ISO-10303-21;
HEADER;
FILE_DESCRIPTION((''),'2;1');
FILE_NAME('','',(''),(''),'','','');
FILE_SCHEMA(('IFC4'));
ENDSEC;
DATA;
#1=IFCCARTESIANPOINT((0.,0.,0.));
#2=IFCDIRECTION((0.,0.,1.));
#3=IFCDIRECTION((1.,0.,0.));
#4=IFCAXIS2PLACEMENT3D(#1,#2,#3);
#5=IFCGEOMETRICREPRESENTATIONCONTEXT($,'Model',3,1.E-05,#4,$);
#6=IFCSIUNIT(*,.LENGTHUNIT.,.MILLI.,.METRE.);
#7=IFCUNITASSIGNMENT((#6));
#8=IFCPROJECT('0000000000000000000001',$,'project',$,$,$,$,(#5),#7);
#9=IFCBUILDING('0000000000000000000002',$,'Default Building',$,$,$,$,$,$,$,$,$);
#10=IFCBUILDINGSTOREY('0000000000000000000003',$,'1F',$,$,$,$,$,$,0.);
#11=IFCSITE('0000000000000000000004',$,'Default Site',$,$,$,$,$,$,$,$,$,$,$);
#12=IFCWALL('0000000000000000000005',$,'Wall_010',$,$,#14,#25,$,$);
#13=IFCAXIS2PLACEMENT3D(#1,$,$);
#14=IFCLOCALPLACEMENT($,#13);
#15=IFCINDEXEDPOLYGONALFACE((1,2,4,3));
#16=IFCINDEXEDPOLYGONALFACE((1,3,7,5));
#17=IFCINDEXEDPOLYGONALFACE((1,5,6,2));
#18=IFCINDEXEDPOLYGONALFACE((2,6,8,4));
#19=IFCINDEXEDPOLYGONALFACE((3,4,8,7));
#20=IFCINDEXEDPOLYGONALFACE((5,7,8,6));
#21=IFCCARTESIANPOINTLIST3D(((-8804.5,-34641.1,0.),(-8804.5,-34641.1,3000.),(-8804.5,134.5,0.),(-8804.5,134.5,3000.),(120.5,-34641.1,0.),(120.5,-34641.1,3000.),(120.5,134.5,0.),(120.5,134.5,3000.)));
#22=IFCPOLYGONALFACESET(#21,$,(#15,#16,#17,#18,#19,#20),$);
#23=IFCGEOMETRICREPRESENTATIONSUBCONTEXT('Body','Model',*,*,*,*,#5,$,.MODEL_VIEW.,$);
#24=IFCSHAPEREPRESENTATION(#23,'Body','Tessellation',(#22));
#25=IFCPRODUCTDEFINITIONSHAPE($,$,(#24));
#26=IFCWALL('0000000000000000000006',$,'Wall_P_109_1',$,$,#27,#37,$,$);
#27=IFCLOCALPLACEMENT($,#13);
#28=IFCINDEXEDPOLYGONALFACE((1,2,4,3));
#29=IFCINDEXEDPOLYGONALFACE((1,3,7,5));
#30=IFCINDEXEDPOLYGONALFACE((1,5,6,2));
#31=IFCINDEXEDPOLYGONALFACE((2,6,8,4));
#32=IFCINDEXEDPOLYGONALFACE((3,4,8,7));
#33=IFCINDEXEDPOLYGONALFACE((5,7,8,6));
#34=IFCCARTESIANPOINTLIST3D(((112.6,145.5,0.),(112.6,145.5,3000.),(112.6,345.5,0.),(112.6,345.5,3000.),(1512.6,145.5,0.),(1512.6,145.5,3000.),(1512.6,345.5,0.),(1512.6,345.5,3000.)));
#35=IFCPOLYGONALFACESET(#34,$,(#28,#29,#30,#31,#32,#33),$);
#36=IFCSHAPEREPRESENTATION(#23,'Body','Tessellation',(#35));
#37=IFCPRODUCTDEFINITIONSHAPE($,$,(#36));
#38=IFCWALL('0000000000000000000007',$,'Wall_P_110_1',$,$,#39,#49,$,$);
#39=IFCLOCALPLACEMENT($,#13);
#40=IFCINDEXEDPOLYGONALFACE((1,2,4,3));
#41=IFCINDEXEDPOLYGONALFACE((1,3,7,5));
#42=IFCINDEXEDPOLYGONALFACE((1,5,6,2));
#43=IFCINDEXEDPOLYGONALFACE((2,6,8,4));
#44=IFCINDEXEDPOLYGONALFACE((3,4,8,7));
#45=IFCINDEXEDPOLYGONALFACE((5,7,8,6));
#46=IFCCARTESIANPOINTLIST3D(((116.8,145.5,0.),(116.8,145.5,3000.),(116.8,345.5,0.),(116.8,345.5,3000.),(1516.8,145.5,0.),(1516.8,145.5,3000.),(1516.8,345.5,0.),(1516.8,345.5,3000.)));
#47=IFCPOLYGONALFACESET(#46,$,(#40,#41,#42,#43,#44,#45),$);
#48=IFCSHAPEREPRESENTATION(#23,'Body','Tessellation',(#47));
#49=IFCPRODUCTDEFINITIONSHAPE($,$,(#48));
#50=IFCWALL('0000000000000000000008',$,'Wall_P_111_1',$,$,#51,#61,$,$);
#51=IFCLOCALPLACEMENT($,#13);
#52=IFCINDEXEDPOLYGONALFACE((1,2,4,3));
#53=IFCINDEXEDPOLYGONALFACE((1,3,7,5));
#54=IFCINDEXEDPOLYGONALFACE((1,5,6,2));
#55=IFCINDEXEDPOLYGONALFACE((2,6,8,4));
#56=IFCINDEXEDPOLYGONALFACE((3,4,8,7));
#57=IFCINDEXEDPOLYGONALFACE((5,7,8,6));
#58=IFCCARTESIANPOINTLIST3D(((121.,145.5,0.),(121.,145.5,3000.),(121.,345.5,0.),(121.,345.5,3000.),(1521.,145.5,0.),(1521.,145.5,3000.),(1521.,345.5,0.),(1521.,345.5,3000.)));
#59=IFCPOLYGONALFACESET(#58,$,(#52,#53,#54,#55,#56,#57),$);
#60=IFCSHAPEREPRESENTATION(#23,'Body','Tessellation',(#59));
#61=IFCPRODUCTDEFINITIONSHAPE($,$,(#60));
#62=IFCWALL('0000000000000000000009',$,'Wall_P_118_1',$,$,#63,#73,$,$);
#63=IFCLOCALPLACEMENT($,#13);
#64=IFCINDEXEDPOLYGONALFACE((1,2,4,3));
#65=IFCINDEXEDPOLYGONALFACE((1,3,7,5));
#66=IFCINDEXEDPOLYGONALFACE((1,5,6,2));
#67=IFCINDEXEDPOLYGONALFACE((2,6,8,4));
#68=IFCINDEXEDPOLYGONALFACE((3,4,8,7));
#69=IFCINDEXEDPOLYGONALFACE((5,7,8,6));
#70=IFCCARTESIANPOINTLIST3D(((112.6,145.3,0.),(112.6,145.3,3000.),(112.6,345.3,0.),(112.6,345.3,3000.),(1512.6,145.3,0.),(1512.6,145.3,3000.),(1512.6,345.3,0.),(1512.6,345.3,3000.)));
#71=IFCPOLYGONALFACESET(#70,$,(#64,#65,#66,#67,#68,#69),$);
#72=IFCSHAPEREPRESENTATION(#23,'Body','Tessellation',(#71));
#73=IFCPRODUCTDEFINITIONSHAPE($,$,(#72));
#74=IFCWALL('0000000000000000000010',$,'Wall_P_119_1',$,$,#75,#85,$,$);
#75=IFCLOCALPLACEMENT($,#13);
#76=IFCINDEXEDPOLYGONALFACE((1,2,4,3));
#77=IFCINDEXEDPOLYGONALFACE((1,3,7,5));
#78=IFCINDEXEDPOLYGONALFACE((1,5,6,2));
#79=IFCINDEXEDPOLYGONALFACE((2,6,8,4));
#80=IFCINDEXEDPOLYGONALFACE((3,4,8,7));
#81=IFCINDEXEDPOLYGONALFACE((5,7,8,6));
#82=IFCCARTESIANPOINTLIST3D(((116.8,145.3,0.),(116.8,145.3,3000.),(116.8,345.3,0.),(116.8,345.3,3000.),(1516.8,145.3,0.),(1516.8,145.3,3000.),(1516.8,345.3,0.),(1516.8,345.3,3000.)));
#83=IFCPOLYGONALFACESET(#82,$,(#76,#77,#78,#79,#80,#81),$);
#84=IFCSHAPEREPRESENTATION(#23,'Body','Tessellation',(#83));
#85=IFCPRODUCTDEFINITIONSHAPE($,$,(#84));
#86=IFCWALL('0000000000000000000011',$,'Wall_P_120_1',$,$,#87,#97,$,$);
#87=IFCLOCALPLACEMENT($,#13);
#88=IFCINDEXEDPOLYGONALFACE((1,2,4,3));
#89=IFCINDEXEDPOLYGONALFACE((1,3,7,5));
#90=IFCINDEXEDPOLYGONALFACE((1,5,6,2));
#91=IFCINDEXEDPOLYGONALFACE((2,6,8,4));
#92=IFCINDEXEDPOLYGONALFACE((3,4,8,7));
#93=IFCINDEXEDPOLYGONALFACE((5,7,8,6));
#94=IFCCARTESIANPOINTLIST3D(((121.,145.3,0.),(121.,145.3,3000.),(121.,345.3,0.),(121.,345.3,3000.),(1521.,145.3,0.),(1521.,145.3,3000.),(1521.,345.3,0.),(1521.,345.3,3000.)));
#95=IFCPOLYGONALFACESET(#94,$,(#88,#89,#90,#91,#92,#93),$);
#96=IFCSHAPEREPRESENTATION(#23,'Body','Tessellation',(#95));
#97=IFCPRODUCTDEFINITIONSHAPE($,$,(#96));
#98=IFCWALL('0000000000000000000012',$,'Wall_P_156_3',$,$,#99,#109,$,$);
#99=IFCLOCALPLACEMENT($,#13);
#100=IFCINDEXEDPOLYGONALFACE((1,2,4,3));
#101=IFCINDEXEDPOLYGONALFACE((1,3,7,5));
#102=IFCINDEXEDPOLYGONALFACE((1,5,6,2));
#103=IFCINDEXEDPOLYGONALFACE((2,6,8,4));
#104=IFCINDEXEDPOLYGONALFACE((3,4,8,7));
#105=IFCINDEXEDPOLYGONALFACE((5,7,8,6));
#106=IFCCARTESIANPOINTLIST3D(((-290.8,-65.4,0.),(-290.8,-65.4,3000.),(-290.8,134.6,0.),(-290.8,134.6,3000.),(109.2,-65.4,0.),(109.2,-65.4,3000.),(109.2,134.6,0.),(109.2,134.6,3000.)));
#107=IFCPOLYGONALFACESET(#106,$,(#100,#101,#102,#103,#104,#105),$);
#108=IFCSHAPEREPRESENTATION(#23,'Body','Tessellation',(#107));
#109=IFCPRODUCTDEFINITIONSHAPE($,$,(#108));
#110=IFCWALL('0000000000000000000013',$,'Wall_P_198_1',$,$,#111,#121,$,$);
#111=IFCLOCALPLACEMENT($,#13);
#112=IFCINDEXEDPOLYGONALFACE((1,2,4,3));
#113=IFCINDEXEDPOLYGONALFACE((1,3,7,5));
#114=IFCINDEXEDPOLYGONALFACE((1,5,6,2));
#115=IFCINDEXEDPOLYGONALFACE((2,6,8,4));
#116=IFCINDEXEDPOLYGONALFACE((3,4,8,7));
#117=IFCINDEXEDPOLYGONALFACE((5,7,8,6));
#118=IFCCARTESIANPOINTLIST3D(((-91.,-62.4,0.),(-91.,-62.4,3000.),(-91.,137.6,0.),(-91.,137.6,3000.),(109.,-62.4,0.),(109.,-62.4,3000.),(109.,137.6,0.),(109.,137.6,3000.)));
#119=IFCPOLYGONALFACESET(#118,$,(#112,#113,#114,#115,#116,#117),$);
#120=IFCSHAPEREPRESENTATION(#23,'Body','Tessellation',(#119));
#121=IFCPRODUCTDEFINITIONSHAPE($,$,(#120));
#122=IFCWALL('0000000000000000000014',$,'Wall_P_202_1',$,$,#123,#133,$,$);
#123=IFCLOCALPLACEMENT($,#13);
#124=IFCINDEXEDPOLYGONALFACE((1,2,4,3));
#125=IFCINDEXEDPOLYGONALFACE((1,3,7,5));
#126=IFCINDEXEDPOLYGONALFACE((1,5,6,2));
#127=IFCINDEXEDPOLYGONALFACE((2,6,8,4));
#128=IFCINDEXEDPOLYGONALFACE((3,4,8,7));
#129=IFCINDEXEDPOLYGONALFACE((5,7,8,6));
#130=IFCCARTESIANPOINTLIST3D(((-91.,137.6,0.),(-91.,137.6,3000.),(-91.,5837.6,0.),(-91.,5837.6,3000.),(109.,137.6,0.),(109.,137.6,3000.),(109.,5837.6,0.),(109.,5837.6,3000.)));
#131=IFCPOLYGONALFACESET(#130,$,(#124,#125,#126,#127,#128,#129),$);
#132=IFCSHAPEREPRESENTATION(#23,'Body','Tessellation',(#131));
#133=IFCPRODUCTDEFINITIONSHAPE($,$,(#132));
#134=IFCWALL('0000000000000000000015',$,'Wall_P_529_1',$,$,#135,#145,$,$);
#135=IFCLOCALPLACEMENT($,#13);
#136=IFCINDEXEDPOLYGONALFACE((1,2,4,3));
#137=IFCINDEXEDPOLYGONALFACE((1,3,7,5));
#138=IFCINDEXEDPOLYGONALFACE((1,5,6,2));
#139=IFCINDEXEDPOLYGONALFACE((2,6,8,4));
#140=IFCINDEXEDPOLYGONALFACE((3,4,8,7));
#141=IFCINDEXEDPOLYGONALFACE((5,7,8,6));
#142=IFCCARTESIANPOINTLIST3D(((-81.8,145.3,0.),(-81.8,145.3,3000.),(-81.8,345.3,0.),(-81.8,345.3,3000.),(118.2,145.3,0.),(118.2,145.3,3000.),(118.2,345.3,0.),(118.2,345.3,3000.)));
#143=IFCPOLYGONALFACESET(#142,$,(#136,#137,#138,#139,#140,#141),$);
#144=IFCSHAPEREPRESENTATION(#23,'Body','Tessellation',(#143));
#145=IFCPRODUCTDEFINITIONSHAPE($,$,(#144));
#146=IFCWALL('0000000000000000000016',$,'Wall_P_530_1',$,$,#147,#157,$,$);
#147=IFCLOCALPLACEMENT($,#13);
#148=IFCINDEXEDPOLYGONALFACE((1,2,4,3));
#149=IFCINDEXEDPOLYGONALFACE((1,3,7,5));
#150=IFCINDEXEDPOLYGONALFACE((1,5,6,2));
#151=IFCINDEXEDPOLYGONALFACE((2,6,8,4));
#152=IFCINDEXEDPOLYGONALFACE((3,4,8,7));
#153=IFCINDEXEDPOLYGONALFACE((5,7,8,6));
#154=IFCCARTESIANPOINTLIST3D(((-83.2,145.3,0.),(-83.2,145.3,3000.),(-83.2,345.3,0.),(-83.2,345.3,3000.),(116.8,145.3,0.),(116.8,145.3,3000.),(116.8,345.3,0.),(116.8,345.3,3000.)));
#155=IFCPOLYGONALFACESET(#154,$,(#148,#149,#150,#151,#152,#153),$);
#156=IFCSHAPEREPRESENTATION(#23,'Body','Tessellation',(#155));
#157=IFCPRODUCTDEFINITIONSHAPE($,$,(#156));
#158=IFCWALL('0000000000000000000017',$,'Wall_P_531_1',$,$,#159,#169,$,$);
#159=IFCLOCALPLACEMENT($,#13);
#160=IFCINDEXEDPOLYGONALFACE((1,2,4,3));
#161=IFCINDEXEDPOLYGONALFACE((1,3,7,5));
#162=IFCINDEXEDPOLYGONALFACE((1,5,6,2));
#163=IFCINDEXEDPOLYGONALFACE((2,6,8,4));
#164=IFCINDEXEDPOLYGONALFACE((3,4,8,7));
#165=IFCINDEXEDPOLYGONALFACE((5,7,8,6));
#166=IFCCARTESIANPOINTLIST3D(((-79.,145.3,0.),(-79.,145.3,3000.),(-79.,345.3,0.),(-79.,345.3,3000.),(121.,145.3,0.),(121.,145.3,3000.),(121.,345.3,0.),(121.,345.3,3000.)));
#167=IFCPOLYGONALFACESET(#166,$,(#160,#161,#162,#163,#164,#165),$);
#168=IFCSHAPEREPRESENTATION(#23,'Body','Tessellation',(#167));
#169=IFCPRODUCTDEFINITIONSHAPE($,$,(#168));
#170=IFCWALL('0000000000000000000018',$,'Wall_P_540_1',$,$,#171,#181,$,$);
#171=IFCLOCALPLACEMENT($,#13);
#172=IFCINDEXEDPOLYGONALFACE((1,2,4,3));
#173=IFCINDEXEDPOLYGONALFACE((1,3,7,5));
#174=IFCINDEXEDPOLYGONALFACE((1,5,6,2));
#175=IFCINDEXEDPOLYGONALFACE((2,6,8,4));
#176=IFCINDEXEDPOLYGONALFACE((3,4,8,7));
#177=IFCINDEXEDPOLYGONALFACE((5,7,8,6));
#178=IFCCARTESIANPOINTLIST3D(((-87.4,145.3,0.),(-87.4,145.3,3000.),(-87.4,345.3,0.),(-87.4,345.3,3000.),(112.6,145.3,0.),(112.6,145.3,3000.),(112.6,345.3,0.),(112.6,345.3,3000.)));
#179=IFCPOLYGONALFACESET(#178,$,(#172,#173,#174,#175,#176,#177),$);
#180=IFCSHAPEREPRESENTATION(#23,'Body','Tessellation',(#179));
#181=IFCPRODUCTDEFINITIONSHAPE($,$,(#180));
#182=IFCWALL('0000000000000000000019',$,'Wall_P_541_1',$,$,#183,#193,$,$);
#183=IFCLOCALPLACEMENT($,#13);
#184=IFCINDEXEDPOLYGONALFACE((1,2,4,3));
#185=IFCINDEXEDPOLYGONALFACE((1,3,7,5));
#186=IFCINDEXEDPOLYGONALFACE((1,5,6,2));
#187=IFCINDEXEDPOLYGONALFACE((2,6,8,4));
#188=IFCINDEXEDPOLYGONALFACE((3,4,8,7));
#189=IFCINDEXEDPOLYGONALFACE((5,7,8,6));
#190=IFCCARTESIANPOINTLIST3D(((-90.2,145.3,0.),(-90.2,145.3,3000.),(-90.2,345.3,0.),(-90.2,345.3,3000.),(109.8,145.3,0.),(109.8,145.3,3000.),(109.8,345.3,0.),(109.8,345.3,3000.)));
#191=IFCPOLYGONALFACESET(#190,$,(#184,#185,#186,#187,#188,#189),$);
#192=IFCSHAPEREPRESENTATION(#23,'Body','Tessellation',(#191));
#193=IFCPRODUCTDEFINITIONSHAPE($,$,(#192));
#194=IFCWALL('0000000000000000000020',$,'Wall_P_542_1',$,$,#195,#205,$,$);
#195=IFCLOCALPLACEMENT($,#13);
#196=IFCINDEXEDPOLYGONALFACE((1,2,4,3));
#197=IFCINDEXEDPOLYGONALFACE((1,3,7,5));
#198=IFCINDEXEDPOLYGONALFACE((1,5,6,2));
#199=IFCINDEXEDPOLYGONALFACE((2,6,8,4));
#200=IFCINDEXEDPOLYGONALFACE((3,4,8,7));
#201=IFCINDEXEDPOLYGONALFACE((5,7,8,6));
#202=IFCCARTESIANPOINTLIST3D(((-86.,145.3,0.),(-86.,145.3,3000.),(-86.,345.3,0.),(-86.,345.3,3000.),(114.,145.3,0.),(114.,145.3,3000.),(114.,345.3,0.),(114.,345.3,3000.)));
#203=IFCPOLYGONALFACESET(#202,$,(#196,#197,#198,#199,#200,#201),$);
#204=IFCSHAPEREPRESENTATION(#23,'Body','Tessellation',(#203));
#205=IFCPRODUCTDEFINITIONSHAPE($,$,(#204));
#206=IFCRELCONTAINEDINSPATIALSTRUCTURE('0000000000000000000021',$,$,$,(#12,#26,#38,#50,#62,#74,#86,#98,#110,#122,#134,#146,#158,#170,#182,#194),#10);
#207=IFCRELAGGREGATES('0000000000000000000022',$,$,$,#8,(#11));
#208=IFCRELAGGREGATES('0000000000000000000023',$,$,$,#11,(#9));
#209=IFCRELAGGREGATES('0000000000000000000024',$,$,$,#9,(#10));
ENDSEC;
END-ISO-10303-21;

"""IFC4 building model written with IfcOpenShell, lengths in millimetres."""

from ifc_helpers import new_model, si_unit, frame, origin_with_axes, place, context, subcontext, project, spatial, indexed_curve, outline, extrude, element, save


model = new_model("IFC4")

# Units and contexts
model_context = context("Model", 3, precision=1e-05, world=origin_with_axes())
body_context = subcontext(model_context, "Body", "Model", "MODEL_VIEW")
ifc_project = project(units=[si_unit("LENGTHUNIT", "METRE", prefix="MILLI")], contexts=[model_context])

# Site, building, storey
site = spatial("IfcSite", under=ifc_project, Name="Default Site")
building = spatial("IfcBuilding", under=site, Name="Default Building")
storey = spatial("IfcBuildingStorey", under=building, Name="1F", Elevation=0.0)

# Walls
wall_1_placement = place(None, frame((120.5, 134.5, 0.0), z_axis=(0.0, 0.0, 1.0), x_axis=(-1.0, 0.0, 0.0)))
element("IfcWall", 1, at=wall_1_placement, inside=storey, Name="Wall_010", context=body_context, shape_type="SweptSolid", body=[
    extrude(outline(indexed_curve([(0.0, 0.0), (0.0, 34775.6), (8925.0, 34775.6), (8925.0, 0.0), (0.0, 0.0)], self_intersect=False)), origin_with_axes(), (0.0, 0.0, 1.0), 3000.0),
])
for number, where, z_axis, x_axis, name in (
    (2, (112.6, 145.5, 0.0), (0.0, 0.0, 1.0), (1.0, 0.0, 0.0), "Wall_P_109_1"),
    (3, (116.8, 145.5, 0.0), (0.0, 0.0, 1.0), (1.0, 0.0, 0.0), "Wall_P_110_1"),
):
    element("IfcWall", number, at=place(None, frame(where, z_axis=z_axis, x_axis=x_axis)), inside=storey, Name=name, context=body_context, shape_type="SweptSolid", body=[
        extrude(outline(indexed_curve([(0.0, 0.0), (0.0, 200.0), (1400.0, 200.0), (1400.0, 0.0), (0.0, 0.0)], self_intersect=False)), origin_with_axes(), (0.0, 0.0, 1.0), 3000.0),
    ])
wall_2_placement = place(None, frame((121.0, 145.5, 0.0), z_axis=(0.0, 0.0, 1.0), x_axis=(1.0, 0.0, 0.0)))
element("IfcWall", 4, at=wall_2_placement, inside=storey, Name="Wall_P_111_1", context=body_context, shape_type="SweptSolid", body=[
    extrude(outline(indexed_curve([(0.0, 0.0), (0.0, 200.0), (1400.0, 200.0), (1400.0, 0.0), (0.0, 0.0)], self_intersect=False)), origin_with_axes(), (0.0, 0.0, 1.0), 3000.0),
])
for number, where, z_axis, x_axis, name in (
    (5, (112.6, 145.3, 0.0), (0.0, 0.0, 1.0), (1.0, 0.0, 0.0), "Wall_P_118_1"),
    (6, (116.8, 145.3, 0.0), (0.0, 0.0, 1.0), (1.0, 0.0, 0.0), "Wall_P_119_1"),
):
    element("IfcWall", number, at=place(None, frame(where, z_axis=z_axis, x_axis=x_axis)), inside=storey, Name=name, context=body_context, shape_type="SweptSolid", body=[
        extrude(outline(indexed_curve([(0.0, 0.0), (0.0, 200.0), (1400.0, 200.0), (1400.0, 0.0), (0.0, 0.0)], self_intersect=False)), origin_with_axes(), (0.0, 0.0, 1.0), 3000.0),
    ])
wall_3_placement = place(None, frame((121.0, 145.3, 0.0), z_axis=(0.0, 0.0, 1.0), x_axis=(1.0, 0.0, 0.0)))
element("IfcWall", 7, at=wall_3_placement, inside=storey, Name="Wall_P_120_1", context=body_context, shape_type="SweptSolid", body=[
    extrude(outline(indexed_curve([(0.0, 0.0), (0.0, 200.0), (1400.0, 200.0), (1400.0, 0.0), (0.0, 0.0)], self_intersect=False)), origin_with_axes(), (0.0, 0.0, 1.0), 3000.0),
])
wall_4_placement = place(None, frame((109.2, 134.6, 0.0), z_axis=(0.0, 0.0, 1.0), x_axis=(-1.0, 0.0, 0.0)))
element("IfcWall", 8, at=wall_4_placement, inside=storey, Name="Wall_P_156_3", context=body_context, shape_type="SweptSolid", body=[
    extrude(outline(indexed_curve([(0.0, 0.0), (0.0, 200.0), (400.0, 200.0), (400.0, 0.0), (0.0, 0.0)], self_intersect=False)), origin_with_axes(), (0.0, 0.0, 1.0), 3000.0),
])
wall_5_placement = place(None, frame((109.0, 137.6, 0.0), z_axis=(0.0, 0.0, 1.0), x_axis=(-1.0, 0.0, 0.0)))
element("IfcWall", 9, at=wall_5_placement, inside=storey, Name="Wall_P_198_1", context=body_context, shape_type="SweptSolid", body=[
    extrude(outline(indexed_curve([(0.0, 0.0), (0.0, 200.0), (200.0, 200.0), (200.0, 0.0), (0.0, 0.0)], self_intersect=False)), origin_with_axes(), (0.0, 0.0, 1.0), 3000.0),
])
wall_6_placement = place(None, frame((109.0, 137.6, 0.0), z_axis=(0.0, 0.0, 1.0), x_axis=(0.0, 1.0, 0.0)))
element("IfcWall", 10, at=wall_6_placement, inside=storey, Name="Wall_P_202_1", context=body_context, shape_type="SweptSolid", body=[
    extrude(outline(indexed_curve([(0.0, 0.0), (0.0, 200.0), (5700.0, 200.0), (5700.0, 0.0), (0.0, 0.0)], self_intersect=False)), origin_with_axes(), (0.0, 0.0, 1.0), 3000.0),
])
wall_7_placement = place(None, frame((118.2, 145.3, 0.0), z_axis=(0.0, 0.0, 1.0), x_axis=(0.0, 1.0, 0.0)))
element("IfcWall", 11, at=wall_7_placement, inside=storey, Name="Wall_P_529_1", context=body_context, shape_type="SweptSolid", body=[
    extrude(outline(indexed_curve([(0.0, 0.0), (0.0, 200.0), (200.0, 200.0), (200.0, 0.0), (0.0, 0.0)], self_intersect=False)), origin_with_axes(), (0.0, 0.0, 1.0), 3000.0),
])
wall_8_placement = place(None, frame((116.8, 145.3, 0.0), z_axis=(0.0, 0.0, 1.0), x_axis=(0.0, 1.0, 0.0)))
element("IfcWall", 12, at=wall_8_placement, inside=storey, Name="Wall_P_530_1", context=body_context, shape_type="SweptSolid", body=[
    extrude(outline(indexed_curve([(0.0, 0.0), (0.0, 200.0), (200.0, 200.0), (200.0, 0.0), (0.0, 0.0)], self_intersect=False)), origin_with_axes(), (0.0, 0.0, 1.0), 3000.0),
])
wall_9_placement = place(None, frame((121.0, 145.3, 0.0), z_axis=(0.0, 0.0, 1.0), x_axis=(0.0, 1.0, 0.0)))
element("IfcWall", 13, at=wall_9_placement, inside=storey, Name="Wall_P_531_1", context=body_context, shape_type="SweptSolid", body=[
    extrude(outline(indexed_curve([(0.0, 0.0), (0.0, 200.0), (200.0, 200.0), (200.0, 0.0), (0.0, 0.0)], self_intersect=False)), origin_with_axes(), (0.0, 0.0, 1.0), 3000.0),
])
wall_10_placement = place(None, frame((112.6, 145.3, 0.0), z_axis=(0.0, 0.0, 1.0), x_axis=(0.0, 1.0, 0.0)))
element("IfcWall", 14, at=wall_10_placement, inside=storey, Name="Wall_P_540_1", context=body_context, shape_type="SweptSolid", body=[
    extrude(outline(indexed_curve([(0.0, 0.0), (0.0, 200.0), (200.0, 200.0), (200.0, 0.0), (0.0, 0.0)], self_intersect=False)), origin_with_axes(), (0.0, 0.0, 1.0), 3000.0),
])
wall_11_placement = place(None, frame((109.8, 145.3, 0.0), z_axis=(0.0, 0.0, 1.0), x_axis=(0.0, 1.0, 0.0)))
element("IfcWall", 15, at=wall_11_placement, inside=storey, Name="Wall_P_541_1", context=body_context, shape_type="SweptSolid", body=[
    extrude(outline(indexed_curve([(0.0, 0.0), (0.0, 200.0), (200.0, 200.0), (200.0, 0.0), (0.0, 0.0)], self_intersect=False)), origin_with_axes(), (0.0, 0.0, 1.0), 3000.0),
])
wall_12_placement = place(None, frame((114.0, 145.3, 0.0), z_axis=(0.0, 0.0, 1.0), x_axis=(0.0, 1.0, 0.0)))
element("IfcWall", 16, at=wall_12_placement, inside=storey, Name="Wall_P_542_1", context=body_context, shape_type="SweptSolid", body=[
    extrude(outline(indexed_curve([(0.0, 0.0), (0.0, 200.0), (200.0, 200.0), (200.0, 0.0), (0.0, 0.0)], self_intersect=False)), origin_with_axes(), (0.0, 0.0, 1.0), 3000.0),
])

save(model, "model.ifc")
